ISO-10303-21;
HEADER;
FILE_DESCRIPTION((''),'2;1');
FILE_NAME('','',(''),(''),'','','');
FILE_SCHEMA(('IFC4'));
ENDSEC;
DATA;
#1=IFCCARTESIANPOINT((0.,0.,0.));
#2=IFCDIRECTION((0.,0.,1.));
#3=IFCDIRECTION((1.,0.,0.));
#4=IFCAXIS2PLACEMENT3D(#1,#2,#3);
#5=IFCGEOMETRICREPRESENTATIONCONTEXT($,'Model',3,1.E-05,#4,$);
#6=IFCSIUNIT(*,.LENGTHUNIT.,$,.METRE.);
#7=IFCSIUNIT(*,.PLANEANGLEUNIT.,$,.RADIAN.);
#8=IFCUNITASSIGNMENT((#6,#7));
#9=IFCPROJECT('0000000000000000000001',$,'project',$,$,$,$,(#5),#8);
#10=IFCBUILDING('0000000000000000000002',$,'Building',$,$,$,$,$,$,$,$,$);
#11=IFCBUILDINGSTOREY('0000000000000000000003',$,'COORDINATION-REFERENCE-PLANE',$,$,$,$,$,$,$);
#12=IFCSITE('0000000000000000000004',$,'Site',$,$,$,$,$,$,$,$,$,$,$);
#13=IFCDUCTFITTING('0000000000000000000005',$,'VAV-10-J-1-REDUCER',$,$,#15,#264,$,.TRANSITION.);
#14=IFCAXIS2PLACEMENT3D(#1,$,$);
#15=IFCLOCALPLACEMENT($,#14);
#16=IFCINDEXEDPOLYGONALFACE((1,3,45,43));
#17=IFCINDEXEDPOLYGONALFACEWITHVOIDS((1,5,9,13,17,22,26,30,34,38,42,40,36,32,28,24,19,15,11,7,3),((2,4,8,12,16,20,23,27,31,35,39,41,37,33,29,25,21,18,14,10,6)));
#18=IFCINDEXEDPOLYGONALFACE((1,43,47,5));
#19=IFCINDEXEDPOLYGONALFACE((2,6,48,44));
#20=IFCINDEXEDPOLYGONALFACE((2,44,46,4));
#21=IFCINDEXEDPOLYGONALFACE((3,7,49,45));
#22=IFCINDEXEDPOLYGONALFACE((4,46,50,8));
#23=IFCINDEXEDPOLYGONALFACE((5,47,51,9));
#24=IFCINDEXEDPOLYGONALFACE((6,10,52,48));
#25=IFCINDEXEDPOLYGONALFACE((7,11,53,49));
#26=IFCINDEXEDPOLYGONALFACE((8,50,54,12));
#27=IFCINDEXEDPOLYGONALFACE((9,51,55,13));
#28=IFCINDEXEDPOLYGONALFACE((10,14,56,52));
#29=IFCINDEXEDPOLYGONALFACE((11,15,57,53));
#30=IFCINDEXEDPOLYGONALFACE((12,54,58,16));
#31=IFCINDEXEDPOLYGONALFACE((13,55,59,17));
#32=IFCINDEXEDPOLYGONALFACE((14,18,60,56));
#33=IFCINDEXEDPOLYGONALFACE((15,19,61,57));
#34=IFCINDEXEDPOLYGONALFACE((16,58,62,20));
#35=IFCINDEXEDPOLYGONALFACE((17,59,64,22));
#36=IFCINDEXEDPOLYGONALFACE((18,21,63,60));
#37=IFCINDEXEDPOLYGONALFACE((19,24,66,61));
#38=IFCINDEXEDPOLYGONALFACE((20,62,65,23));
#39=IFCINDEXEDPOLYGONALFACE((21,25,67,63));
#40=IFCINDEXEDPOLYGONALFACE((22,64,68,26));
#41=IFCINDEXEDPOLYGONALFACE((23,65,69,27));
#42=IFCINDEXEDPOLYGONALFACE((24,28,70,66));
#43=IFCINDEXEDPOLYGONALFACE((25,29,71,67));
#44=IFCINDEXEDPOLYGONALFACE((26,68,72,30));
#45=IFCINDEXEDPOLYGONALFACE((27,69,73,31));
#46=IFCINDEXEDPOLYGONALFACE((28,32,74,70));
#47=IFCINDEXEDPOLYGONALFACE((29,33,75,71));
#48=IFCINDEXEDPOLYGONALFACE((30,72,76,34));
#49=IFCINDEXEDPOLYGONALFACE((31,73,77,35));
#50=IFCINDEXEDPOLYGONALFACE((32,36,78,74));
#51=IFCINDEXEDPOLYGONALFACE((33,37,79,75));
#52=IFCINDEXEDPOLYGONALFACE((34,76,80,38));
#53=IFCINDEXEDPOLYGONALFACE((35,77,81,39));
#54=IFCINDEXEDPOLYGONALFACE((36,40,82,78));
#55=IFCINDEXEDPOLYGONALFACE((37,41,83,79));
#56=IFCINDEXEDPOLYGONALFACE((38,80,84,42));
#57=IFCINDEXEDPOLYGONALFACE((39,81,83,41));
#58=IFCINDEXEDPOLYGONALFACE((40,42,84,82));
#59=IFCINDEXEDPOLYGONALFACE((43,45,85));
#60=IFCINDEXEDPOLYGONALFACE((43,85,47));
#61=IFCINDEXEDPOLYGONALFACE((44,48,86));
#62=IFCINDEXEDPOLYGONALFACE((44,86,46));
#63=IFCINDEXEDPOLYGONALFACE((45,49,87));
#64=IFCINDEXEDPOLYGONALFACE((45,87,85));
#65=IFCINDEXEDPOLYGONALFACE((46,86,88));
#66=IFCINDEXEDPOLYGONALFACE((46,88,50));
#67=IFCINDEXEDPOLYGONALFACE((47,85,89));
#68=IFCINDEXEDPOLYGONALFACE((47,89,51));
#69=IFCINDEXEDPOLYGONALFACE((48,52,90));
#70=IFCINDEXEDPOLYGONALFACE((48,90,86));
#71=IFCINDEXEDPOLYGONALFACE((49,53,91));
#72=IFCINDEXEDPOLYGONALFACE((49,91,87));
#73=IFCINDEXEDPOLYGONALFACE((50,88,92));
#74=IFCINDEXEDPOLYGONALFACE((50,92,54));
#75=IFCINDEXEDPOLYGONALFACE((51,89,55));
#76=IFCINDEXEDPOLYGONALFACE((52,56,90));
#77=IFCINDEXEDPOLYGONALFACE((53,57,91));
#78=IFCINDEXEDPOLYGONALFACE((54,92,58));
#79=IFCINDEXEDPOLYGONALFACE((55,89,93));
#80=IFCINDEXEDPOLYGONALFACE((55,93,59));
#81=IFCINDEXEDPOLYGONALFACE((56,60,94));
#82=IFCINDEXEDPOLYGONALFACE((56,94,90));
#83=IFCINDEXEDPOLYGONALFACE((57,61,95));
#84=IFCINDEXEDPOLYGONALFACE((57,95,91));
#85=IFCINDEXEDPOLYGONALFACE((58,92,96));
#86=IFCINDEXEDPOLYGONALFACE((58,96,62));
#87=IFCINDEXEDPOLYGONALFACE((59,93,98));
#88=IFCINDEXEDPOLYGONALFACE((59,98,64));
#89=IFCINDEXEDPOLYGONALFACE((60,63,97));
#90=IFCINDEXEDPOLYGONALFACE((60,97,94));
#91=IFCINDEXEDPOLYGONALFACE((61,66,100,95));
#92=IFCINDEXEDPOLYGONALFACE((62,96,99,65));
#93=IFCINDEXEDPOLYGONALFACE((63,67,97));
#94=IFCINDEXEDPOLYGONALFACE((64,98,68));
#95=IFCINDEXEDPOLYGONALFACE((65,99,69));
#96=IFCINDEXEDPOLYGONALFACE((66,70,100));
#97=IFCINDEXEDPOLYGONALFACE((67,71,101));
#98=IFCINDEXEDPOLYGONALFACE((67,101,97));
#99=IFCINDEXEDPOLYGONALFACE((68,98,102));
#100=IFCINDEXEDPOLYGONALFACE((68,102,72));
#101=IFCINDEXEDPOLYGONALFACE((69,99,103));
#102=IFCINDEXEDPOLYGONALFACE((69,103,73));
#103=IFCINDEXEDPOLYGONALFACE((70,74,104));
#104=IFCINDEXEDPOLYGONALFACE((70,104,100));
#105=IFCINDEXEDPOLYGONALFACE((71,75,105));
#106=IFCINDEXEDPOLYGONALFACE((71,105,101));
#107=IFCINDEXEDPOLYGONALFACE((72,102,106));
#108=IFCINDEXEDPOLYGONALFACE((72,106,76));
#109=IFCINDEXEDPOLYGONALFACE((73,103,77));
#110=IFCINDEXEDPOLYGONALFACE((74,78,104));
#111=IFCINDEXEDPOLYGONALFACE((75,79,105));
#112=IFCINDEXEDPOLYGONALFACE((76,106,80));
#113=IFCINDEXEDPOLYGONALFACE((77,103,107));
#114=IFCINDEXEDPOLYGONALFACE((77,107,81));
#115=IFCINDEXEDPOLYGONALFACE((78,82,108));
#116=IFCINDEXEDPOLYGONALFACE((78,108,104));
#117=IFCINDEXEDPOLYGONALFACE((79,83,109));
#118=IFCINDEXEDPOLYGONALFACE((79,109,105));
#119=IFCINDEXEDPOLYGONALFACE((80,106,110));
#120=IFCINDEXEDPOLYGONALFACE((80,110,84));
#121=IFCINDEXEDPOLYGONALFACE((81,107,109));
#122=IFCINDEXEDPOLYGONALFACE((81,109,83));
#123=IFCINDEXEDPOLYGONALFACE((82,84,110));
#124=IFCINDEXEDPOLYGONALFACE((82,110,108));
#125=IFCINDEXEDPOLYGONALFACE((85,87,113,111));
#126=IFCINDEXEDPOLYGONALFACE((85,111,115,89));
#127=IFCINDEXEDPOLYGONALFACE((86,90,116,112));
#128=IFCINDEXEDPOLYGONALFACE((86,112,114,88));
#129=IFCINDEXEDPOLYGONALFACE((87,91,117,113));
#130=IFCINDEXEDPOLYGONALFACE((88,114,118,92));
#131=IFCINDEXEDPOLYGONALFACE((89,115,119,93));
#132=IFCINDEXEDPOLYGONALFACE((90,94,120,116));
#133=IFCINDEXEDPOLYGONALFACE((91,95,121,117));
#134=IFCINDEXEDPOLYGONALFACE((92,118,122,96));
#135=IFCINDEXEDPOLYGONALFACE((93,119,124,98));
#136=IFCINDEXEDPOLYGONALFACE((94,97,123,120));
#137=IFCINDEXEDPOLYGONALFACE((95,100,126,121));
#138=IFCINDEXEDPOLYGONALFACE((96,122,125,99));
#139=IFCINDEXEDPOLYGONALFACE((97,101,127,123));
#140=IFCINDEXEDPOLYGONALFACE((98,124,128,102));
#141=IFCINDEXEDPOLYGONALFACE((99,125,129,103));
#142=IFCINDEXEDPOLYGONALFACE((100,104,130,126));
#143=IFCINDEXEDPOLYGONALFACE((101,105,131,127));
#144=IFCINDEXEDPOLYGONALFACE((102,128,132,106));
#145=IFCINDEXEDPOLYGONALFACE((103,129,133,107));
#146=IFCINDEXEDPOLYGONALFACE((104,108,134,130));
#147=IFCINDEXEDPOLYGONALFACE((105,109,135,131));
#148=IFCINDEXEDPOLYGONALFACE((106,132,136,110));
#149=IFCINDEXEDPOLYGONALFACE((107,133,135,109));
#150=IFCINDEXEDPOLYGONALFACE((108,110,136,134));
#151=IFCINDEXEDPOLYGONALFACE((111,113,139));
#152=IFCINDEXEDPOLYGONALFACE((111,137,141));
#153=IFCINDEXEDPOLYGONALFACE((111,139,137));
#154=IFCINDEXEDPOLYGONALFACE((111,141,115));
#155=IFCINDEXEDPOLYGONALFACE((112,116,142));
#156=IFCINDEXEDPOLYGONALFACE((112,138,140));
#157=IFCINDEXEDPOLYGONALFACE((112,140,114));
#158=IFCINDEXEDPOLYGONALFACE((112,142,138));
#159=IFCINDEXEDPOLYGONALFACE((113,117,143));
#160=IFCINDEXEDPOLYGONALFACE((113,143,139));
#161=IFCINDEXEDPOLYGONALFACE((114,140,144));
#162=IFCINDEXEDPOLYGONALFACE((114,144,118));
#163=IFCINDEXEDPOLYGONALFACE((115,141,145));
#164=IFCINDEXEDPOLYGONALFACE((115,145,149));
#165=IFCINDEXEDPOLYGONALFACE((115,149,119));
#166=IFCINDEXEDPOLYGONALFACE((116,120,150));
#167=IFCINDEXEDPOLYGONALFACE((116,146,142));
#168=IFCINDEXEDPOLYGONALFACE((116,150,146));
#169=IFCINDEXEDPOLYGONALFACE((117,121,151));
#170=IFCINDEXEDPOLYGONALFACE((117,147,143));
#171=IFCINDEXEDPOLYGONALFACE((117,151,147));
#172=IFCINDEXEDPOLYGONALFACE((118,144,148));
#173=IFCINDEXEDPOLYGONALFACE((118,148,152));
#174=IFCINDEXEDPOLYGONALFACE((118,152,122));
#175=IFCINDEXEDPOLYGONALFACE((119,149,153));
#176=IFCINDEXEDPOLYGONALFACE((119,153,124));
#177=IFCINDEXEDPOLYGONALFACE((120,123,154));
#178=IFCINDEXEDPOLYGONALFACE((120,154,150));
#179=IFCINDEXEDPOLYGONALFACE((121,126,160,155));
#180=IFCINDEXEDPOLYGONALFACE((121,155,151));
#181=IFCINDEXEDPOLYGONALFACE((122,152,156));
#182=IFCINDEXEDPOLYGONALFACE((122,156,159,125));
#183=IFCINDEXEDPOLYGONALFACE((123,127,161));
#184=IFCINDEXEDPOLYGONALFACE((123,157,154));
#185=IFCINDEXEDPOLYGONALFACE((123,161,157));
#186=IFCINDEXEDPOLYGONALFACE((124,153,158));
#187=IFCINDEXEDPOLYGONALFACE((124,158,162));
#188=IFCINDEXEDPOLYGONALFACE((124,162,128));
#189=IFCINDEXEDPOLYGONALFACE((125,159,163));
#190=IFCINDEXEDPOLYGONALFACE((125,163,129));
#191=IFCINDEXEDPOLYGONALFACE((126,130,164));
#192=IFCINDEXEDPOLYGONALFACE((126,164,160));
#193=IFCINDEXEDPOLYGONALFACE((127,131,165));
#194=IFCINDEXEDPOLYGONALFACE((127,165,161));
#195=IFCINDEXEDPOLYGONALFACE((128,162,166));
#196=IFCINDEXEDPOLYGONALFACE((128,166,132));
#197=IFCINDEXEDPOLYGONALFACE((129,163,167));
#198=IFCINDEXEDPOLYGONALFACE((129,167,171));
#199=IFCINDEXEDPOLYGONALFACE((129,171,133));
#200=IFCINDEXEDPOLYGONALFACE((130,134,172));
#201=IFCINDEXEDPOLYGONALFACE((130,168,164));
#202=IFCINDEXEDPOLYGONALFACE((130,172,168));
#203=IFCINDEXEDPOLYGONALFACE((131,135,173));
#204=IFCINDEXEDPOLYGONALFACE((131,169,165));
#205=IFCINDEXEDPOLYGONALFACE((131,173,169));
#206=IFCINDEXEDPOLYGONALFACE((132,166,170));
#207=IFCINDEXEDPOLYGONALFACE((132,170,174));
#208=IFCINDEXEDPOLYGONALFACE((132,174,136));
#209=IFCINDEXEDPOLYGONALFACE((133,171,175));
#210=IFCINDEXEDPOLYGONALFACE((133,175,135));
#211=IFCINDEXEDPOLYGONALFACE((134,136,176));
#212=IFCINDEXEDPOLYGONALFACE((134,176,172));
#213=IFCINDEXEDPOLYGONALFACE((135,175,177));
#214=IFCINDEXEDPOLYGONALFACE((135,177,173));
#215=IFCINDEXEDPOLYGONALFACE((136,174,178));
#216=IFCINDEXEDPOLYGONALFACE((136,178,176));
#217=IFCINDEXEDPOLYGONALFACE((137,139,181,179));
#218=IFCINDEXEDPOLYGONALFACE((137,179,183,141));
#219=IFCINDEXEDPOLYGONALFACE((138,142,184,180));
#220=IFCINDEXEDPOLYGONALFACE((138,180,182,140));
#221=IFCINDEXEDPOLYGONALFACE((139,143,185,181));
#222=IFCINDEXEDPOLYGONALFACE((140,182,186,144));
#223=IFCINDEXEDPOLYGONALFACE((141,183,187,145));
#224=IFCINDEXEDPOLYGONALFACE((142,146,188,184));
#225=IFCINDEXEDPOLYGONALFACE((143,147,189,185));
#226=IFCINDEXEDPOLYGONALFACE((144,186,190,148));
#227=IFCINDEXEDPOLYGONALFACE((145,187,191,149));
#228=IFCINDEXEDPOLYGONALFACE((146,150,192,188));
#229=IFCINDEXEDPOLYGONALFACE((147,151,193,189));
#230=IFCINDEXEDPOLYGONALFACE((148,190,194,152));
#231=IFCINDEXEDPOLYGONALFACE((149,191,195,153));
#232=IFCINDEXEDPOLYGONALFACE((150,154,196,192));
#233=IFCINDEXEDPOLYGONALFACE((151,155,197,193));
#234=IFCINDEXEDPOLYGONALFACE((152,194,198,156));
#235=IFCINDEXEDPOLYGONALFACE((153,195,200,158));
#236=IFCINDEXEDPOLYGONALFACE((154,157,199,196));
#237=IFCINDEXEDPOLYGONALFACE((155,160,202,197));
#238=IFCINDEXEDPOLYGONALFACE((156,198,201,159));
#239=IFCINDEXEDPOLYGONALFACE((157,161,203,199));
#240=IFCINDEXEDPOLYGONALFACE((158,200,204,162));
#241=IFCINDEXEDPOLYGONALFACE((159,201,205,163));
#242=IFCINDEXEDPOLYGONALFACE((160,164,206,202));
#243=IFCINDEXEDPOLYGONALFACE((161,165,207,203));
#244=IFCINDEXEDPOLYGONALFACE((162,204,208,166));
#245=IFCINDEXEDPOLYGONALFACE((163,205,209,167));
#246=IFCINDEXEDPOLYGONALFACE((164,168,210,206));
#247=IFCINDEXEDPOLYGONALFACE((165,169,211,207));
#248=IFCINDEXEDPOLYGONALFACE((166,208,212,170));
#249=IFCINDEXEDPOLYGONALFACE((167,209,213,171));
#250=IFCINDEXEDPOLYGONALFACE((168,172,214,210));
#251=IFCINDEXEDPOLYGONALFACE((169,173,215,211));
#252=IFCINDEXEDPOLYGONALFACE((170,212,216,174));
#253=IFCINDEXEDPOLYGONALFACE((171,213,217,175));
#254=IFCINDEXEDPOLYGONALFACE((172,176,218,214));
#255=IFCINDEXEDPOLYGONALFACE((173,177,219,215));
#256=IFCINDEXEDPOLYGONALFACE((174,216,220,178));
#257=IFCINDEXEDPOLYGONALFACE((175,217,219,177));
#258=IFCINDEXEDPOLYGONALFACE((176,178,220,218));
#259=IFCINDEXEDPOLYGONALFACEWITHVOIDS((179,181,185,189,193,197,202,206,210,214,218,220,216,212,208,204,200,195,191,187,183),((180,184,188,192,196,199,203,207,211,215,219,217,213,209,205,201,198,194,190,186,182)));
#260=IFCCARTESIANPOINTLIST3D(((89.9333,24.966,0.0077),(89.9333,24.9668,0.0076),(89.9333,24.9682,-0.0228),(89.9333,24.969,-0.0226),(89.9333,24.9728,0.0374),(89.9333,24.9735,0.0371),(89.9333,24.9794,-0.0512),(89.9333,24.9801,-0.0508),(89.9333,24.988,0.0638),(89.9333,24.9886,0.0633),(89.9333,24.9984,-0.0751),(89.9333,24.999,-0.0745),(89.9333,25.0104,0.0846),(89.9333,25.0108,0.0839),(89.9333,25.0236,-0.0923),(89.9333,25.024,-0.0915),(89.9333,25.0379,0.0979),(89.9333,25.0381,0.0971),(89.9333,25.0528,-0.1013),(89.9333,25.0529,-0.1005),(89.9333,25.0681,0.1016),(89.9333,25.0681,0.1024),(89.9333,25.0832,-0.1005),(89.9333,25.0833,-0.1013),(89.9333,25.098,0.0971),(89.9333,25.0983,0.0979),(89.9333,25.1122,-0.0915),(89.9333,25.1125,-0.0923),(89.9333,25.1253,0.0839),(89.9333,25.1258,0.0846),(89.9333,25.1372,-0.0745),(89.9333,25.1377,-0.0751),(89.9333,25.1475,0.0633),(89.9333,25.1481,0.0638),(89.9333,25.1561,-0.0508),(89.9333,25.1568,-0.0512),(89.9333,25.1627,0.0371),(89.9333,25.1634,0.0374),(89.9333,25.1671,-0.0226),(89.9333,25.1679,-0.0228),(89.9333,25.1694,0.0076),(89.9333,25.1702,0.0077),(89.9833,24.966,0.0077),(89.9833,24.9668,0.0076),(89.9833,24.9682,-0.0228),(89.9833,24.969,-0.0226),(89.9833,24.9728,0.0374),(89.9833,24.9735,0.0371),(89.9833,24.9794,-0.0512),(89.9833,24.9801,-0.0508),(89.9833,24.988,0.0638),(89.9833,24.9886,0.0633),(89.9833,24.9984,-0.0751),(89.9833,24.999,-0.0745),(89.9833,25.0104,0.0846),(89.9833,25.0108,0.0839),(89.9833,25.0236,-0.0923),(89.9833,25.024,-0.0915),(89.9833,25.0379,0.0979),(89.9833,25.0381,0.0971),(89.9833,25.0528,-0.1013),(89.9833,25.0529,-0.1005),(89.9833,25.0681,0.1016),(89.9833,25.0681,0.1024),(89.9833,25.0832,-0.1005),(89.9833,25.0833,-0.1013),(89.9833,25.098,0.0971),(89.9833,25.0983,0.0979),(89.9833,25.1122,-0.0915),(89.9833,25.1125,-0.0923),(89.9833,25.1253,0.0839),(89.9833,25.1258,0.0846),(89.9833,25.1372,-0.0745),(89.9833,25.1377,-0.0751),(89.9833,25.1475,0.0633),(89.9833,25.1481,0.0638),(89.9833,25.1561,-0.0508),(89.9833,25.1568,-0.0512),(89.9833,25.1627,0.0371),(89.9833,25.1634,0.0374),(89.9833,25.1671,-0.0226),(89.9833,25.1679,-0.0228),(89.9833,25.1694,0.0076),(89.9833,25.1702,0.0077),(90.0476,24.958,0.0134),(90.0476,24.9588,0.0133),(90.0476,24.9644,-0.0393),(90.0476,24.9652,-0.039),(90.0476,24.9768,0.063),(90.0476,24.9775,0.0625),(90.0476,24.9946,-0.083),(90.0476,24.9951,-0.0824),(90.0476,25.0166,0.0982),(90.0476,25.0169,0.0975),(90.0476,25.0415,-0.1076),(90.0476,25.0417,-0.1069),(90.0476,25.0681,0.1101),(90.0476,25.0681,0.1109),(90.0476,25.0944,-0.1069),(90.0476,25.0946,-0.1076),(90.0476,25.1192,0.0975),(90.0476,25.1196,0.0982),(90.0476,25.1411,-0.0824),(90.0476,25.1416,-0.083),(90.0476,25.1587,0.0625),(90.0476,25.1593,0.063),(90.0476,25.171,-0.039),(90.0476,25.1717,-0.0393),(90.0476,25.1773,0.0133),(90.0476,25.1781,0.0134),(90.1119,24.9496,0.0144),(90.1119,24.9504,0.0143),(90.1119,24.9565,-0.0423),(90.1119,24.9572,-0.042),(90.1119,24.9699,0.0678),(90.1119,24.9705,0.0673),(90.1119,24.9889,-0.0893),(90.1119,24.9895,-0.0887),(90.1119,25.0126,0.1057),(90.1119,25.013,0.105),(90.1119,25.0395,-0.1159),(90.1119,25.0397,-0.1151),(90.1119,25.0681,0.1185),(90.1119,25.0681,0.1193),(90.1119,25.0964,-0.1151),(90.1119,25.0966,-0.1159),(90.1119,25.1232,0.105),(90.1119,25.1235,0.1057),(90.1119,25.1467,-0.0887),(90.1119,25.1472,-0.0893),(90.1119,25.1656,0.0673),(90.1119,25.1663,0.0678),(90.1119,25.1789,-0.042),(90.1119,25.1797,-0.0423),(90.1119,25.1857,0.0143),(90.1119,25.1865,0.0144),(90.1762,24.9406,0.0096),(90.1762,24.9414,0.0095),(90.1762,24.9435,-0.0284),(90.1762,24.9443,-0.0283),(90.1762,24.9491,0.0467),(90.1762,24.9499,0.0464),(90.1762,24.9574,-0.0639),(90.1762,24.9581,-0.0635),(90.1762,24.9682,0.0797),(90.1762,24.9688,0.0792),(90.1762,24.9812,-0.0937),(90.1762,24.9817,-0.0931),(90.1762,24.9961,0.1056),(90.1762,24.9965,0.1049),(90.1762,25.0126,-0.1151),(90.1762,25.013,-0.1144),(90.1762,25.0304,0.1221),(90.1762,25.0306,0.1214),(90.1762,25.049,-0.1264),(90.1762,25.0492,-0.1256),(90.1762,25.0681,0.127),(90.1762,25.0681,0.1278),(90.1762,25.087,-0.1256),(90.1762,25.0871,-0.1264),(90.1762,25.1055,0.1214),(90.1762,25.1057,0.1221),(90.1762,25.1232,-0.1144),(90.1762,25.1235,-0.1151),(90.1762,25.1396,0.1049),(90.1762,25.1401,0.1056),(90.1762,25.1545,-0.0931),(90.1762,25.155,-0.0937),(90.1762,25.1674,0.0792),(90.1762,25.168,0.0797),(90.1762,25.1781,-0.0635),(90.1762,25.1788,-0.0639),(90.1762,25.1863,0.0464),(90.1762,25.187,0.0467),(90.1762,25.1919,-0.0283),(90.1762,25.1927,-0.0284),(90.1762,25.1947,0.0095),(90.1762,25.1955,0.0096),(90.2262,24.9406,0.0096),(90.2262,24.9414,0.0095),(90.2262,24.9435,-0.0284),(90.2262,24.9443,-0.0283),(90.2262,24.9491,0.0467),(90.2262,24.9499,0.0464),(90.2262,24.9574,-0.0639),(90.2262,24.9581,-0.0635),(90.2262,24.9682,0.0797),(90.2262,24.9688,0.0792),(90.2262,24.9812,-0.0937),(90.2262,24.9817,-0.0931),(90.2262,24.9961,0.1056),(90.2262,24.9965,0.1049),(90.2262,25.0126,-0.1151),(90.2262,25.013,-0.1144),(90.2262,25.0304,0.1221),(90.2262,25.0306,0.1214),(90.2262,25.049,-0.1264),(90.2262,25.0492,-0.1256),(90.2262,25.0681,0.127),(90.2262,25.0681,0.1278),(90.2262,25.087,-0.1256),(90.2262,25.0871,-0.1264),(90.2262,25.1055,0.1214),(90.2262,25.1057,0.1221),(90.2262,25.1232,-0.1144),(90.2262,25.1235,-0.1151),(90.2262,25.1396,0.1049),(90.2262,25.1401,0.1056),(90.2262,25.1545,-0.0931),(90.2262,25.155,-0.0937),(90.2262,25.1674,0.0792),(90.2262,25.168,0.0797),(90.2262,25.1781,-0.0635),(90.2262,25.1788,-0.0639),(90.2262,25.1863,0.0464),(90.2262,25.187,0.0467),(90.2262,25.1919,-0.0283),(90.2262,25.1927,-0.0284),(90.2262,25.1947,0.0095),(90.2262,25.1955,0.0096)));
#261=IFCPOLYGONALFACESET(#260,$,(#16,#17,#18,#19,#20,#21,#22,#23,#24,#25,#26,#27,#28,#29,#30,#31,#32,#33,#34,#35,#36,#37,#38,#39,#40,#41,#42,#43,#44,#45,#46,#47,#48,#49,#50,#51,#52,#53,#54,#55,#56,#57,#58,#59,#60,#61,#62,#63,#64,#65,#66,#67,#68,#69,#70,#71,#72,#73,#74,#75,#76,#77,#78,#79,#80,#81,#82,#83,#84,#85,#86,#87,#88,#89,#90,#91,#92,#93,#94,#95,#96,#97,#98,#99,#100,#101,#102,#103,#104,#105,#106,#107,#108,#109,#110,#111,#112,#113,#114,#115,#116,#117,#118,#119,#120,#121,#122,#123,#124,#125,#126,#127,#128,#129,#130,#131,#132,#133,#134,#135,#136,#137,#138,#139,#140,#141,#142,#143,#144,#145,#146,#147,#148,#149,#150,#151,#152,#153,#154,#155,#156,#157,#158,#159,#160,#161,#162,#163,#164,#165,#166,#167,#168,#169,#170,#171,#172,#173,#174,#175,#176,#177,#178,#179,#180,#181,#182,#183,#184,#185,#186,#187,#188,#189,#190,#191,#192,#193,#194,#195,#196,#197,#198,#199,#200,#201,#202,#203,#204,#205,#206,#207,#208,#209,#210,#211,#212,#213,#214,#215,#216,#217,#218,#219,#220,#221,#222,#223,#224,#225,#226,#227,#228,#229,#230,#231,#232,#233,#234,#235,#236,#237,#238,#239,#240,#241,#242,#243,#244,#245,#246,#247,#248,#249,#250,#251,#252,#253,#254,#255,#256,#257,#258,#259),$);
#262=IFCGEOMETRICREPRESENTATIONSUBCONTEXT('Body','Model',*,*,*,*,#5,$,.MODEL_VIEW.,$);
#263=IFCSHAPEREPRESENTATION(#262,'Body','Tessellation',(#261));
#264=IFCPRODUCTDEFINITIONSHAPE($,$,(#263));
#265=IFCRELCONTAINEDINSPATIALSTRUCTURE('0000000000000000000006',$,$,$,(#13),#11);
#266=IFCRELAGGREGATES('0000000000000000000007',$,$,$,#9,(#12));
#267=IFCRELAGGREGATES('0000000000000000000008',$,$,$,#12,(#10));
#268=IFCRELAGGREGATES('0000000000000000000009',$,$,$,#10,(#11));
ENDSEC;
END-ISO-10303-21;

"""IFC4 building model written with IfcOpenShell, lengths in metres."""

from ifc_helpers import new_model, entity, si_unit, frame, origin_with_axes, place, context, subcontext, project, spatial, element, save


model = new_model("IFC4")

# Units and contexts
model_context_1 = context("Model", 3, precision=1e-05, world=origin_with_axes())
body_context_1 = subcontext(model_context_1, "Body", "Model", "MODEL_VIEW")
ifc_project = project(units=[si_unit("LENGTHUNIT", "METRE"), si_unit("PLANEANGLEUNIT", "RADIAN")], contexts=[model_context_1])

# Site, building, storey
site = spatial("IfcSite", under=ifc_project, Name="Site")
building = spatial("IfcBuilding", under=site, Name="Building")
storey = spatial("IfcBuildingStorey", under=building, Name="COORDINATION-REFERENCE-PLANE")

# Duct fitting
for number, where, z_axis, x_axis, name in (
    (1, (90.2262, 25.0681, 0.0), (0.0, -1.0, 0.0), (0.0, 0.0, 1.0), "VAV-10-J-1-REDUCER"),
):
    element("IfcDuctFitting", number, at=place(None, frame(where, z_axis=z_axis, x_axis=x_axis)), inside=storey, Name=name, PredefinedType="TRANSITION", context=body_context_1, shape_type="SweptSolid", body=[
        entity("IfcRevolvedAreaSolid", entity("IfcArbitraryClosedProfileDef", "AREA", None, entity("IfcPolyline", [entity("IfcCartesianPoint", [0.1278, 0.0]), entity("IfcCartesianPoint", [0.1278, 0.05]), entity("IfcCartesianPoint", [0.1024, 0.2429]), entity("IfcCartesianPoint", [0.1024, 0.2929]), entity("IfcCartesianPoint", [0.1016, 0.2929]), entity("IfcCartesianPoint", [0.1016, 0.2429]), entity("IfcCartesianPoint", [0.127, 0.05]), entity("IfcCartesianPoint", [0.127, 0.0]), entity("IfcCartesianPoint", [0.1278, 0.0])])), entity("IfcAxis2Placement3D", entity("IfcCartesianPoint", [0.0, 0.0, 0.0])), entity("IfcAxis1Placement", entity("IfcCartesianPoint", [0.0, 0.0, 0.0]), entity("IfcDirection", [0.0, 1.0, 0.0])), 6.283185),
    ])

save(model, "model.ifc")
